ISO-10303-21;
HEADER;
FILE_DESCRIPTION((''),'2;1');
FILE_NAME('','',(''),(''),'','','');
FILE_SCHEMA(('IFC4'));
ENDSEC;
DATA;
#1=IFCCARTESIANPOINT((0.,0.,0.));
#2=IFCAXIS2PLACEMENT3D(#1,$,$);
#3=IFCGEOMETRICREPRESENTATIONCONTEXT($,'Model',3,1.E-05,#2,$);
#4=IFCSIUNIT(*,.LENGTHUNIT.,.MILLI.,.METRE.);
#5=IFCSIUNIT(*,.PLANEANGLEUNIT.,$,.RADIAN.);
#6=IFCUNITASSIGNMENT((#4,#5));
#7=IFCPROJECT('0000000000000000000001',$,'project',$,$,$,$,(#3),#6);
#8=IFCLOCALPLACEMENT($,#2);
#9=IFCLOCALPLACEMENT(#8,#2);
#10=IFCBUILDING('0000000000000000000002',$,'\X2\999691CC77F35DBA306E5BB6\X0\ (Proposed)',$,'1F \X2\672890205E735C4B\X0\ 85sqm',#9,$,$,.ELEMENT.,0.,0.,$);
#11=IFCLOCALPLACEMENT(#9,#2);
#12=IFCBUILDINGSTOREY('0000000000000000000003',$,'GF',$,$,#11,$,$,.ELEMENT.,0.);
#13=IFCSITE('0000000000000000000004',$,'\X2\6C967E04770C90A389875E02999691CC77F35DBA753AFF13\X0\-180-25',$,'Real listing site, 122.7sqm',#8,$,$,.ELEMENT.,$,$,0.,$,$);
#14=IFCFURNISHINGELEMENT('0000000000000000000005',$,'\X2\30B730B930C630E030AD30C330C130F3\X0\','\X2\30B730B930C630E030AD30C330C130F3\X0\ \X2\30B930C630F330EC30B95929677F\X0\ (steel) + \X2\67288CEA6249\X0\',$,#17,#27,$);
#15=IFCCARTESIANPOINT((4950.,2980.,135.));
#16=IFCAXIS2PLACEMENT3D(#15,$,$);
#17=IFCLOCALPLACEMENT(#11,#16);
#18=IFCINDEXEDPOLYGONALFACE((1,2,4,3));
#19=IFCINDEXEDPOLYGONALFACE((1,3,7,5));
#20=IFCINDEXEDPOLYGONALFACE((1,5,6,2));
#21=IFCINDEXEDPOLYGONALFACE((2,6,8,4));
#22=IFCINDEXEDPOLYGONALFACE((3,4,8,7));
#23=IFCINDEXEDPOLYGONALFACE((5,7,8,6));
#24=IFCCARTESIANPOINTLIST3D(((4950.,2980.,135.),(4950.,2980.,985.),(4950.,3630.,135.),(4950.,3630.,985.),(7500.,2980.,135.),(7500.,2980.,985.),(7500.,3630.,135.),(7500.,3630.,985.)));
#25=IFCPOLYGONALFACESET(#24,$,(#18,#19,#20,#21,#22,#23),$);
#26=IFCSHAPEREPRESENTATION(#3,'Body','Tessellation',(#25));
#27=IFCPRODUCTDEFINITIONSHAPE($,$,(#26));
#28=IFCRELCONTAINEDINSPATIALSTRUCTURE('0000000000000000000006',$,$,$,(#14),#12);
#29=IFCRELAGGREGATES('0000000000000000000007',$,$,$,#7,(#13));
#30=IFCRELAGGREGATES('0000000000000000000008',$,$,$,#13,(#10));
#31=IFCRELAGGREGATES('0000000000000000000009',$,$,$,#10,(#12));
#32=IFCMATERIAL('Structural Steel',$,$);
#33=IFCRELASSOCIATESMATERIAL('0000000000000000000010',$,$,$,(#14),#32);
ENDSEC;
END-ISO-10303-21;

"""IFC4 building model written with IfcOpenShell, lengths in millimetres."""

from ifc_helpers import new_model, si_unit, frame, frame_2d, origin, place, context, project, spatial, rectangle, extrude, material, element, save


model = new_model("IFC4")

# Units and contexts
model_context = context("Model", 3, precision=1e-05, world=origin())
ifc_project = project(units=[si_unit("LENGTHUNIT", "METRE", prefix="MILLI"), si_unit("PLANEANGLEUNIT", "RADIAN")], contexts=[model_context])

# Site, building, storey
site_placement = place(None, origin())
site = spatial("IfcSite", under=ifc_project, at=site_placement, Name="沖縄県那覇市首里石嶺町３-180-25", ObjectType="Real listing site, 122.7sqm", CompositionType="ELEMENT", RefElevation=0.0)
building_placement = place(site_placement, origin())
building = spatial("IfcBuilding", under=site, at=building_placement, Name="首里石嶺の家 (Proposed)", ObjectType="1F 木造平屋 85sqm", CompositionType="ELEMENT", ElevationOfRefHeight=0.0, ElevationOfTerrain=0.0)
storey_placement = place(building_placement, origin())
storey = spatial("IfcBuildingStorey", under=building, at=storey_placement, Name="GF", CompositionType="ELEMENT", Elevation=0.0)

# Furnishing element
ifc_material_1 = material(Name="Structural Steel")
furnishing_1_placement = place(storey_placement, frame((4950.0, 2980.0, 135.0)))
element("IfcFurnishingElement", 1, at=furnishing_1_placement, inside=storey, material=ifc_material_1, Name="システムキッチン", Description="システムキッチン ステンレス天板 (steel) + 木質扉", context=model_context, shape_type="SweptSolid", body=[
    extrude(rectangle(XDim=2550.0, YDim=650.0, at=frame_2d((1275.0, 325.0))), frame((4950.0, 2980.0, 135.0)), (0.0, 0.0, 1.0), 850.0),
])

save(model, "model.ifc")
